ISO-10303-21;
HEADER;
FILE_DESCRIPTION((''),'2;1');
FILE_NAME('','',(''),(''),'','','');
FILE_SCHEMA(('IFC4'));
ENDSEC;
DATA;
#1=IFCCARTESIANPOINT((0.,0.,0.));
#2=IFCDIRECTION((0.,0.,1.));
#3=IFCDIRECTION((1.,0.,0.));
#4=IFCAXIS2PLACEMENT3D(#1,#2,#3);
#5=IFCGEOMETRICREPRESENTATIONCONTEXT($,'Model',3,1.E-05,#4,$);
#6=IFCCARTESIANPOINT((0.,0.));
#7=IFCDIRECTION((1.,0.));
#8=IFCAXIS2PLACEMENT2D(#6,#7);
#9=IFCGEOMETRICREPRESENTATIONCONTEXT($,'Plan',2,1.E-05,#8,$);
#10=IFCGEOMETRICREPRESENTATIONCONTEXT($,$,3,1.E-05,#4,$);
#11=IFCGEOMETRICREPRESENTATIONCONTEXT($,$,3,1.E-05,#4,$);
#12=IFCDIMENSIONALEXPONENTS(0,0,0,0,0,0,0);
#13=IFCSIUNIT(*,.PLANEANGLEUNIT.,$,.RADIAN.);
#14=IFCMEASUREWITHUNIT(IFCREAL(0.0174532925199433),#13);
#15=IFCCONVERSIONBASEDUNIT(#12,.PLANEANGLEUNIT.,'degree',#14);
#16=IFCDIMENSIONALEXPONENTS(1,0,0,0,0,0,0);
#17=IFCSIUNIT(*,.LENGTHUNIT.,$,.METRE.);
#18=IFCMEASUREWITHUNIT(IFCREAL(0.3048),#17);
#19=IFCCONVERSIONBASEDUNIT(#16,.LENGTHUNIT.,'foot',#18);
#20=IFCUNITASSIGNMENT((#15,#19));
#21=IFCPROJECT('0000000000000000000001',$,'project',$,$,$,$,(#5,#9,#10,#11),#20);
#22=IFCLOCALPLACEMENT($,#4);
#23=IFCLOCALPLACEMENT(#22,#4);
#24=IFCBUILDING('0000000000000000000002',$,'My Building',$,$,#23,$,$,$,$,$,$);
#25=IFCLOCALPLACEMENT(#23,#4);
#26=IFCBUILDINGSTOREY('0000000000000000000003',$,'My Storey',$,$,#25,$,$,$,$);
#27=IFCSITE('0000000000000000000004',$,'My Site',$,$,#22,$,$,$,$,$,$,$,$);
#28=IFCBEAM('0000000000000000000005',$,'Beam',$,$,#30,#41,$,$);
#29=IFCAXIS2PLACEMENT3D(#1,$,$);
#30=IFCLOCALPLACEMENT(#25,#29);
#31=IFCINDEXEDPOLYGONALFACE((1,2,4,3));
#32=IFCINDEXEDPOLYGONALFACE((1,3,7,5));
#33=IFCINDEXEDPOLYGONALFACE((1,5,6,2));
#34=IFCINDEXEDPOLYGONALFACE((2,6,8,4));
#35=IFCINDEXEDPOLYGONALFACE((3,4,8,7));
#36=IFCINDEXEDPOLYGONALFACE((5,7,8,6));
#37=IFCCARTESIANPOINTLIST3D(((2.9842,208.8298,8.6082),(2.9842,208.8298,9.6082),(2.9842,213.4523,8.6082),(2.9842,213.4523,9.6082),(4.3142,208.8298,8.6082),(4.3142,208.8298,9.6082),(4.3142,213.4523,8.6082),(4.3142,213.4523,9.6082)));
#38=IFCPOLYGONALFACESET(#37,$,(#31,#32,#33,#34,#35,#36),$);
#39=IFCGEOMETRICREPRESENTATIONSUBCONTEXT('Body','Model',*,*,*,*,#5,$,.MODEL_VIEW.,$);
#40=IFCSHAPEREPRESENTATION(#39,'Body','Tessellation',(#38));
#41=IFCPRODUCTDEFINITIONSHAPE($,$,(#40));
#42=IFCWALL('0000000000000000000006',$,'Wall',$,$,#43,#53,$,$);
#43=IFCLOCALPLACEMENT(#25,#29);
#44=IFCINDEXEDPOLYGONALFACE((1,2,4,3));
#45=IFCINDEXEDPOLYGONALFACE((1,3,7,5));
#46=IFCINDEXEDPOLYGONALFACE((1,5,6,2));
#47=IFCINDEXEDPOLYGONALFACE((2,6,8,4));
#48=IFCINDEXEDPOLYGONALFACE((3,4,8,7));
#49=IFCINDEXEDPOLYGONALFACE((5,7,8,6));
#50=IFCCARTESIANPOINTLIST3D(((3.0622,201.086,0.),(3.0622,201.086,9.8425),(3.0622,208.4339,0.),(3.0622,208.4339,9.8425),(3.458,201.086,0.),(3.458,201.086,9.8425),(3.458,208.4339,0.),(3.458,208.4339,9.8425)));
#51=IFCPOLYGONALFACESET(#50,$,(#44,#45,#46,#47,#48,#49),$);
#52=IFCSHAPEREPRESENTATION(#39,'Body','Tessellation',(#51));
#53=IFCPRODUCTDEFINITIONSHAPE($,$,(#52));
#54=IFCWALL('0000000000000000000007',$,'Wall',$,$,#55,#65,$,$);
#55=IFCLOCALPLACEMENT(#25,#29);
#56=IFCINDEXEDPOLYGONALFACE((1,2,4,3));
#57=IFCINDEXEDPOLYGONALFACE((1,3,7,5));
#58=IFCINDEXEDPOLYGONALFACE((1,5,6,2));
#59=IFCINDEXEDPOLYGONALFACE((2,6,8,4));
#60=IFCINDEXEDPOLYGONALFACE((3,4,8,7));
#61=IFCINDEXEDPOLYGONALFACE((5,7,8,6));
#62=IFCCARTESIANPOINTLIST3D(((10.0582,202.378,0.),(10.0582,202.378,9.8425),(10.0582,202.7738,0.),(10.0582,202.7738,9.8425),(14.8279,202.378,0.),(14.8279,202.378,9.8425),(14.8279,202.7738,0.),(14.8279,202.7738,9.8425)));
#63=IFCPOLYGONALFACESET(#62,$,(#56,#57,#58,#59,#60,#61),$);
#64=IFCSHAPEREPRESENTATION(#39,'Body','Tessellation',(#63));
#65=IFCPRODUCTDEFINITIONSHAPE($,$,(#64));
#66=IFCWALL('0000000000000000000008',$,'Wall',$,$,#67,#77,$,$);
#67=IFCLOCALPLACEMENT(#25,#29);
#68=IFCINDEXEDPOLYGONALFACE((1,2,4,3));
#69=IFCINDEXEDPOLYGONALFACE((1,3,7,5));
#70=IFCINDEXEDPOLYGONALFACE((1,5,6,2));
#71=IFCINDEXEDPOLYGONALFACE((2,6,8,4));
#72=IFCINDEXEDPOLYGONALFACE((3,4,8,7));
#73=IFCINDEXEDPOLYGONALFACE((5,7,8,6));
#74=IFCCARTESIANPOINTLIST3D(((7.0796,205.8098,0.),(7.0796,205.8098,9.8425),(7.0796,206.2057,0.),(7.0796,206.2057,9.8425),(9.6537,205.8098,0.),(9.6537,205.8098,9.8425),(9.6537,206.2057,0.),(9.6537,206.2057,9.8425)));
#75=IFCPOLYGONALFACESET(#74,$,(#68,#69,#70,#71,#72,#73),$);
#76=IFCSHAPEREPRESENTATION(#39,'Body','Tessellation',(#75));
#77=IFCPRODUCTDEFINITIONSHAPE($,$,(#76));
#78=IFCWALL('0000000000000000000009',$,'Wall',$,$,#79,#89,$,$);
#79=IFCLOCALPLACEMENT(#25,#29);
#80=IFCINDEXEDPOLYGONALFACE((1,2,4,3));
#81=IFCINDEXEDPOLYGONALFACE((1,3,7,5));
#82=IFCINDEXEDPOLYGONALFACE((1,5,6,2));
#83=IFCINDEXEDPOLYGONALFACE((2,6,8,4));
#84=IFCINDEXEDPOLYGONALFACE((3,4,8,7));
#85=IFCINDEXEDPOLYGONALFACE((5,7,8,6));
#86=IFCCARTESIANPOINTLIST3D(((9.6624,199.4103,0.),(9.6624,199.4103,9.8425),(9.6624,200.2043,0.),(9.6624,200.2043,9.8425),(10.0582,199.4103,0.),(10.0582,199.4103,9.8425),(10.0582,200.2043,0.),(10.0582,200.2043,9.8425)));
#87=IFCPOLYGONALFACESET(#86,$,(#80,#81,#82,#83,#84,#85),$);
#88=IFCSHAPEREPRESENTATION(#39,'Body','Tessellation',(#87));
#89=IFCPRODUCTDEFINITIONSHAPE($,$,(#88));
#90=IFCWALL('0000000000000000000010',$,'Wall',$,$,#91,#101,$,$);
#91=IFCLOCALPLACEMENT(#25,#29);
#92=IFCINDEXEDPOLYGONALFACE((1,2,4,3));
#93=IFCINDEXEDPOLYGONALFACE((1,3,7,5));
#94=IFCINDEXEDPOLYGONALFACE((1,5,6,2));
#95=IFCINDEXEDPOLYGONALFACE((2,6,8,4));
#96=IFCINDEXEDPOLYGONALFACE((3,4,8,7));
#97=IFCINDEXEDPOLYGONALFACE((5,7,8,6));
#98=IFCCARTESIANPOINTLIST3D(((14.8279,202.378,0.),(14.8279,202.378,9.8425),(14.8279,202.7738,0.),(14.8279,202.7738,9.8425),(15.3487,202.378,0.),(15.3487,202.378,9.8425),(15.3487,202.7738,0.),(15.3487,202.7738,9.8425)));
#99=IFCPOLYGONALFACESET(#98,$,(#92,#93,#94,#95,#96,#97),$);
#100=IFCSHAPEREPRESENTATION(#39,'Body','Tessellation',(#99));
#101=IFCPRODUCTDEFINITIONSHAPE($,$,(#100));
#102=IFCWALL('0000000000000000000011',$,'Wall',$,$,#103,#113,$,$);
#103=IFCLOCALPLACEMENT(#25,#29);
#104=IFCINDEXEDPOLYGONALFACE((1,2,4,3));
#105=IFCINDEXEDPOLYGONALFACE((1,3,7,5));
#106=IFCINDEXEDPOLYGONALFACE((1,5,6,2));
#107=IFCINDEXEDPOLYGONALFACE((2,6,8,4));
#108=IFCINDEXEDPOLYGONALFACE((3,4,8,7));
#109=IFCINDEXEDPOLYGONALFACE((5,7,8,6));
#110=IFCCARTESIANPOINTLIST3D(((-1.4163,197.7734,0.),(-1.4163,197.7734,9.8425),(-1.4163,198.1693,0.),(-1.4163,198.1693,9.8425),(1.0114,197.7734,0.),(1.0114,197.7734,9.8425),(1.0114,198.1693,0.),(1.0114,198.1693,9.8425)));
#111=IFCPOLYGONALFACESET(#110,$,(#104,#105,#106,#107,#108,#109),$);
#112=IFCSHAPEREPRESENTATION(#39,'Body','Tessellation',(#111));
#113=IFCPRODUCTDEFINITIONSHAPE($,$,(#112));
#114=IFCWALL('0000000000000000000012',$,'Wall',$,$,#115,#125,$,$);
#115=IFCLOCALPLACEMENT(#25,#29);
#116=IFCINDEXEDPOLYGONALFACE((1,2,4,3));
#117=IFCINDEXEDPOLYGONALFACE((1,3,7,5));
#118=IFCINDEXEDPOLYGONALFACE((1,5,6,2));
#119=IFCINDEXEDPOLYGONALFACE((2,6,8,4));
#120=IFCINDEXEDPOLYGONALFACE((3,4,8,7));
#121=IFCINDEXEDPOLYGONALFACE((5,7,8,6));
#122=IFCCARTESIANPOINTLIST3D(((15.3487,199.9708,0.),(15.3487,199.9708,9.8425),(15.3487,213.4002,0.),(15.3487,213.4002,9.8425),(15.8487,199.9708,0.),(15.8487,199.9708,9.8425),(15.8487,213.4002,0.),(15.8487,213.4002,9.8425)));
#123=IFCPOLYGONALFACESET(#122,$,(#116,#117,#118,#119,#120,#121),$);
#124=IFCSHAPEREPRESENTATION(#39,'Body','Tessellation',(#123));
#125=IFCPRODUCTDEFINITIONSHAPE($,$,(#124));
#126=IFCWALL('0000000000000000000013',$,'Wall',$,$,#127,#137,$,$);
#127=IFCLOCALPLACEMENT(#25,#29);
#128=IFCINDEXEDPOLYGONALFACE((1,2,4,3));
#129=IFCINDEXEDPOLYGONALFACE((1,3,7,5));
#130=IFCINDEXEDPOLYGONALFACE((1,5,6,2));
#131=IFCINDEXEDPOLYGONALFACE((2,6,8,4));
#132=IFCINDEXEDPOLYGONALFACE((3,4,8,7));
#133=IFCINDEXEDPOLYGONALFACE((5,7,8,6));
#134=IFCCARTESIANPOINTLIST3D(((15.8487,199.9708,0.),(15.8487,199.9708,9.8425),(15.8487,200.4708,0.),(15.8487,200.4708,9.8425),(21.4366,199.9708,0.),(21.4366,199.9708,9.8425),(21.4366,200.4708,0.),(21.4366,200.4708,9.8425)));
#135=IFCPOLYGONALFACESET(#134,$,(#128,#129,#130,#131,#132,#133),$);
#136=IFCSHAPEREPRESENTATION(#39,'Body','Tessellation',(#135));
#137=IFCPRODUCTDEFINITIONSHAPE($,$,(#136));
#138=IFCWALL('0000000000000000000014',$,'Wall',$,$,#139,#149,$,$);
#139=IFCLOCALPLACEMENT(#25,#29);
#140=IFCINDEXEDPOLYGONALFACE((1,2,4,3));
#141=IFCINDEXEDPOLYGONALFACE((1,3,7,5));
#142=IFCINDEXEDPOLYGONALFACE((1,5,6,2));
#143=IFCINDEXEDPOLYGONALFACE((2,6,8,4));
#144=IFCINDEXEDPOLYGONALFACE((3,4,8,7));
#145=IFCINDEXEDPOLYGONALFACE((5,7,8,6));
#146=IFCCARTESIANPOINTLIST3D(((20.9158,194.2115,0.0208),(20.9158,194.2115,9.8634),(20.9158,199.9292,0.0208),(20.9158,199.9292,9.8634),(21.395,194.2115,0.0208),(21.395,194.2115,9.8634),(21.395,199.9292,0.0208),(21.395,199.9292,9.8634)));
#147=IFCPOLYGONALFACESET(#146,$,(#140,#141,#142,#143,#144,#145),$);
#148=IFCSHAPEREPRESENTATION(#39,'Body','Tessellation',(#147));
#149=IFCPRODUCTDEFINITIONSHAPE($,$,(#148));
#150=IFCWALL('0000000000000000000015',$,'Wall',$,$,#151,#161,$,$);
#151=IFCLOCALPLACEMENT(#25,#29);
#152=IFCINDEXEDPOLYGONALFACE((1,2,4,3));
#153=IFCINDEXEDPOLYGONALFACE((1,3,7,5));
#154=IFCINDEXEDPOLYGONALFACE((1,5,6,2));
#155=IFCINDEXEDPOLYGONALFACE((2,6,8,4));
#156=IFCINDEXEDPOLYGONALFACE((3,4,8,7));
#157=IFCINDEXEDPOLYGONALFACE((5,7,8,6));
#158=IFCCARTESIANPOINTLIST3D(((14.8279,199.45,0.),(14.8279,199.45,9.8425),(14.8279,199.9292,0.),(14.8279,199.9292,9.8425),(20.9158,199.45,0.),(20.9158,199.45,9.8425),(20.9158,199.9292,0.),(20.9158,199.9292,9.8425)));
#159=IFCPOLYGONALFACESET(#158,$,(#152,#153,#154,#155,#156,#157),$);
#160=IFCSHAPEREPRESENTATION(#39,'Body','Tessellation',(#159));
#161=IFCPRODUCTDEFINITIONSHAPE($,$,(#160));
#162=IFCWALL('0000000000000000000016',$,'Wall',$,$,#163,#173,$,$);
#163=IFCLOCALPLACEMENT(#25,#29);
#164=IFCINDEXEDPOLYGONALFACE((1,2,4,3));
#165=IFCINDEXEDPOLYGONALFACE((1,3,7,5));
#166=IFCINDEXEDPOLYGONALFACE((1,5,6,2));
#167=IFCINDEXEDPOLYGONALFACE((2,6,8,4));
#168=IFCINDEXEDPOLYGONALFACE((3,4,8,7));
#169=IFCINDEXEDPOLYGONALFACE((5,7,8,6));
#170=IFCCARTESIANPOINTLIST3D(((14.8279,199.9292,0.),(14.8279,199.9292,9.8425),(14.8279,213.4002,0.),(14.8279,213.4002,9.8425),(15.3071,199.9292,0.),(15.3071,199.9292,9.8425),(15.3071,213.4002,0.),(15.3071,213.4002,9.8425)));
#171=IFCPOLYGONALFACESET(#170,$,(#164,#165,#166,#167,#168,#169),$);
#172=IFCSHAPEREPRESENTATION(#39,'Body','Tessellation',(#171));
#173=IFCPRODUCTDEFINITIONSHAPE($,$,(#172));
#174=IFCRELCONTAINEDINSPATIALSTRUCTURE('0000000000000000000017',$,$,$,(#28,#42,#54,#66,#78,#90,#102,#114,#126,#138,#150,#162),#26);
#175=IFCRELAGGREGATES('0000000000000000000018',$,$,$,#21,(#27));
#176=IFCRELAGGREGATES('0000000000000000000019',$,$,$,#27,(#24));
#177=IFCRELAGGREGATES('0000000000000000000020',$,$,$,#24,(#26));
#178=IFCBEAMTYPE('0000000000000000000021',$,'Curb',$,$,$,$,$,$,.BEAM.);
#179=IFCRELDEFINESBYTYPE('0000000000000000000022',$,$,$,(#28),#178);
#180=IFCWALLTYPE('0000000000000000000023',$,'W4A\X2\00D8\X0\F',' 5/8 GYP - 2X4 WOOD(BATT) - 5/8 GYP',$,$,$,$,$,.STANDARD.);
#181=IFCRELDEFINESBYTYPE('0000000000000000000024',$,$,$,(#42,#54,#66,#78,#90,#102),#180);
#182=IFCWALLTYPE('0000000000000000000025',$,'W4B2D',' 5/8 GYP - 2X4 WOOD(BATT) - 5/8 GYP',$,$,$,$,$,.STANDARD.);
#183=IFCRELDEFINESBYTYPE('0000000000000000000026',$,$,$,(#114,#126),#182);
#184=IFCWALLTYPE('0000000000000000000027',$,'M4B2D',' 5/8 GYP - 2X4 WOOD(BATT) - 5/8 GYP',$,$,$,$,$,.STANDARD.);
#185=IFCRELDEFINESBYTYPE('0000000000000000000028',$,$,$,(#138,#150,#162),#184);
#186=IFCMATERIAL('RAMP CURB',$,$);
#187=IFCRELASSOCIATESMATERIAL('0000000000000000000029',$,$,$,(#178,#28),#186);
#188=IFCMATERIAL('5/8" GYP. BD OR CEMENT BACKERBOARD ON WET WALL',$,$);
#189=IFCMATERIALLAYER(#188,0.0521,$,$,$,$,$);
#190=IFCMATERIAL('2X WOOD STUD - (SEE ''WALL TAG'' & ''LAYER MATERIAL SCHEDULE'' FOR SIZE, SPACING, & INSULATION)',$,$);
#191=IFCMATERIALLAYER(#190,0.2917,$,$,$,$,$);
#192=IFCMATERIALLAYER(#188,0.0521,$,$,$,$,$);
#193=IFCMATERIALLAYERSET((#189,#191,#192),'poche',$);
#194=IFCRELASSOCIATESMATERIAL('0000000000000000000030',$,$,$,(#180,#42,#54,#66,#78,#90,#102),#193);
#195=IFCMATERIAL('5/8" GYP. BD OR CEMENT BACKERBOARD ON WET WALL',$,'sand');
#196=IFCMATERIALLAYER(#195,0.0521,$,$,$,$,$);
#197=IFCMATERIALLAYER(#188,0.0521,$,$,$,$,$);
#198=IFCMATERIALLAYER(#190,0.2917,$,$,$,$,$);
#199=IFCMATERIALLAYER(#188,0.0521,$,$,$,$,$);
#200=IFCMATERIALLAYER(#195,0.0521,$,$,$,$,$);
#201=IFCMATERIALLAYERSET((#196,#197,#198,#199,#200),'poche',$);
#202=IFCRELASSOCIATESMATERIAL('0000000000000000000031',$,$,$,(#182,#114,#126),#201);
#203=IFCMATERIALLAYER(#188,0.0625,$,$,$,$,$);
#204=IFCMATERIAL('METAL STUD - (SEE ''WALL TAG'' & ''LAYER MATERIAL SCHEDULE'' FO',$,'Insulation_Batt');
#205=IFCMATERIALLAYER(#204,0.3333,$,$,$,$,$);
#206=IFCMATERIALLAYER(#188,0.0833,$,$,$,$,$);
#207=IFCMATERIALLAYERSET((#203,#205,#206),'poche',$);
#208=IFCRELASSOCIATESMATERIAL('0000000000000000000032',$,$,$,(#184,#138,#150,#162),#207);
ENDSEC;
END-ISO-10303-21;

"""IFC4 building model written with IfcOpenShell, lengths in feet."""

from ifc_helpers import new_model, entity, si_unit, converted_unit, frame, origin_with_axes, origin_2d_with_axis, place, context, subcontext, project, spatial, indexed_curve, rectangle, outline, extrude, material, layer, layer_set, layer_usage, material_profile, profile_set, profile_usage, type_object, element, save


model = new_model("IFC4")

# Units and contexts
model_context = context("Model", 3, precision=1e-05, world=origin_with_axes())
plan_context = context("Plan", 2, precision=1e-05, world=origin_2d_with_axis())
context_of_model_1 = context(None, 3, precision=1e-05, world=origin_with_axes())
context_of_model_2 = context(None, 3, precision=1e-05, world=origin_with_axes())
body_context = subcontext(model_context, "Body", "Model", "MODEL_VIEW")
ifc_project = project(units=[converted_unit("PLANEANGLEUNIT", "degree", entity("IfcReal", 0.0174532925199433), si_unit("PLANEANGLEUNIT", "RADIAN"), dimensions=[0, 0, 0, 0, 0, 0, 0]), converted_unit("LENGTHUNIT", "foot", entity("IfcReal", 0.3048), si_unit("LENGTHUNIT", "METRE"), dimensions=[1, 0, 0, 0, 0, 0, 0])], contexts=[model_context, plan_context, context_of_model_1, context_of_model_2])

# Site, building, storey
site_placement = place(None, origin_with_axes())
site = spatial("IfcSite", under=ifc_project, at=site_placement, Name="My Site")
building_placement = place(site_placement, origin_with_axes())
building = spatial("IfcBuilding", under=site, at=building_placement, Name="My Building")
storey_placement = place(building_placement, origin_with_axes())
storey = spatial("IfcBuildingStorey", under=building, at=storey_placement, Name="My Storey")

# Beam
ifc_material_1 = material(Name="RAMP CURB")
ifc_material_profile = material_profile(ifc_material_1, rectangle(XDim=1.33, YDim=1.0))
ifc_profile_set = profile_set([ifc_material_profile])
ifc_profile_usage = profile_usage(ifc_profile_set, cardinal=5)
beam_type = type_object("IfcBeamType", Name="Curb", PredefinedType="BEAM", material=ifc_profile_set)
beam_placement = place(storey_placement, frame((3.6492, 208.8298, 9.1082), z_axis=(0.0, 1.0, 0.0), x_axis=(-1.0, 0.0, 0.0)))
element("IfcBeam", 1, at=beam_placement, inside=storey, type_object=beam_type, material=ifc_profile_usage, Name="Beam", context=body_context, shape_type="SweptSolid", body=[
    extrude(rectangle(XDim=1.33, YDim=1.0), origin_with_axes(), (0.0, 0.0, 1.0), 4.6225),
])

# Walls
ifc_material_2 = material(Name="5/8\" GYP. BD OR CEMENT BACKERBOARD ON WET WALL")
ifc_layer_1 = layer(ifc_material_2, 0.0521)
ifc_material_3 = material(Name="2X WOOD STUD - (SEE 'WALL TAG' & 'LAYER MATERIAL SCHEDULE' FOR SIZE, SPACING, & INSULATION)")
ifc_layer_2 = layer(ifc_material_3, 0.2917)
ifc_layer_3 = layer(ifc_material_2, 0.0521)
ifc_layer_set_1 = layer_set([ifc_layer_1, ifc_layer_2, ifc_layer_3], Name="poche")
ifc_layer_usage_1 = layer_usage(ifc_layer_set_1, "AXIS2", "POSITIVE", 0.0)
wall_type_1 = type_object("IfcWallType", Name="W4AØF", Description=" 5/8 GYP - 2X4 WOOD(BATT) - 5/8 GYP", PredefinedType="STANDARD", material=ifc_layer_set_1)
wall_1_placement = place(storey_placement, frame((3.458, 201.086, 0.0), z_axis=(0.0, 0.0, 1.0), x_axis=(0.000001, 1.0, 0.0)))
element("IfcWall", 2, at=wall_1_placement, inside=storey, type_object=wall_type_1, material=ifc_layer_usage_1, Name="Wall", context=body_context, shape_type="SweptSolid", body=[
    extrude(outline(indexed_curve([(0.0, 0.0), (0.0, 0.3958), (7.3479, 0.3958), (7.3479, 0.0), (0.0, 0.0)], self_intersect=False)), origin_with_axes(), (0.0, 0.0, 1.0), 9.8425),
])
ifc_layer_usage_2 = layer_usage(ifc_layer_set_1, "AXIS2", "POSITIVE", 0.0)
wall_2_placement = place(storey_placement, frame((10.0582, 202.378, 0.0), z_axis=(0.0, 0.0, 1.0), x_axis=(1.0, 0.0, 0.0)))
element("IfcWall", 3, at=wall_2_placement, inside=storey, type_object=wall_type_1, material=ifc_layer_usage_2, Name="Wall", context=body_context, shape_type="SweptSolid", body=[
    extrude(outline(indexed_curve([(0.0, 0.0), (0.0, 0.3958), (4.7697, 0.3958), (4.7697, 0.0), (0.0, 0.0)], self_intersect=False)), origin_with_axes(), (0.0, 0.0, 1.0), 9.8425),
])
ifc_layer_usage_3 = layer_usage(ifc_layer_set_1, "AXIS2", "POSITIVE", 0.0)
wall_3_placement = place(storey_placement, frame((9.6537, 206.2057, 0.0), z_axis=(0.0, 0.0, 1.0), x_axis=(-1.0, 0.0, 0.0)))
element("IfcWall", 4, at=wall_3_placement, inside=storey, type_object=wall_type_1, material=ifc_layer_usage_3, Name="Wall", context=body_context, shape_type="SweptSolid", body=[
    extrude(outline(indexed_curve([(0.0, 0.0), (0.0, 0.3958), (2.5741, 0.3958), (2.5741, 0.0), (0.0, 0.0)], self_intersect=False)), origin_with_axes(), (0.0, 0.0, 1.0), 9.8425),
])

# Walls
ifc_layer_usage_4 = layer_usage(ifc_layer_set_1, "AXIS2", "POSITIVE", 0.0)
wall_4_placement = place(storey_placement, frame((10.0582, 199.4103, 0.0), z_axis=(0.0, 0.0, 1.0), x_axis=(0.000001, 1.0, 0.0)))
element("IfcWall", 5, at=wall_4_placement, inside=storey, type_object=wall_type_1, material=ifc_layer_usage_4, Name="Wall", context=body_context, shape_type="SweptSolid", body=[
    extrude(outline(indexed_curve([(0.0, 0.0), (0.0, 0.3958), (0.794, 0.3958), (0.794, 0.0), (0.0, 0.0)], self_intersect=False)), origin_with_axes(), (0.0, 0.0, 1.0), 9.8425),
])
ifc_layer_usage_5 = layer_usage(ifc_layer_set_1, "AXIS2", "POSITIVE", 0.0)
wall_5_placement = place(storey_placement, frame((15.3487, 202.7738, 0.0), z_axis=(0.0, 0.0, 1.0), x_axis=(-1.0, 0.0, 0.0)))
element("IfcWall", 6, at=wall_5_placement, inside=storey, type_object=wall_type_1, material=ifc_layer_usage_5, Name="Wall", context=body_context, shape_type="SweptSolid", body=[
    extrude(outline(indexed_curve([(0.0, 0.0), (0.0, 0.3958), (0.5208, 0.3958), (0.5208, 0.0), (0.0, 0.0)], self_intersect=False)), origin_with_axes(), (0.0, 0.0, 1.0), 9.8425),
])
ifc_layer_usage_6 = layer_usage(ifc_layer_set_1, "AXIS2", "POSITIVE", 0.0)
wall_6_placement = place(storey_placement, frame((-1.4163, 197.7734, 0.0), z_axis=(0.0, 0.0, 1.0), x_axis=(1.0, -0.000001, 0.0)))
element("IfcWall", 7, at=wall_6_placement, inside=storey, type_object=wall_type_1, material=ifc_layer_usage_6, Name="Wall", context=body_context, shape_type="SweptSolid", body=[
    extrude(outline(indexed_curve([(0.0, 0.0), (0.0, 0.3958), (2.4277, 0.3958), (2.4277, 0.0), (0.0, 0.0)], self_intersect=False)), origin_with_axes(), (0.0, 0.0, 1.0), 9.8425),
])

# Walls
ifc_material_4 = material(Name="5/8\" GYP. BD OR CEMENT BACKERBOARD ON WET WALL", Category="sand")
ifc_layer_4 = layer(ifc_material_4, 0.0521)
ifc_layer_5 = layer(ifc_material_2, 0.0521)
ifc_layer_6 = layer(ifc_material_3, 0.2917)
ifc_layer_7 = layer(ifc_material_2, 0.0521)
ifc_layer_8 = layer(ifc_material_4, 0.0521)
ifc_layer_set_2 = layer_set([ifc_layer_4, ifc_layer_5, ifc_layer_6, ifc_layer_7, ifc_layer_8], Name="poche")
ifc_layer_usage_7 = layer_usage(ifc_layer_set_2, "AXIS2", "POSITIVE", 0.0)
wall_type_2 = type_object("IfcWallType", Name="W4B2D", Description=" 5/8 GYP - 2X4 WOOD(BATT) - 5/8 GYP", PredefinedType="STANDARD", material=ifc_layer_set_2)
wall_7_placement = place(storey_placement, frame((15.8487, 199.9708, 0.0), z_axis=(0.0, 0.0, 1.0), x_axis=(0.000001, 1.0, 0.0)))
element("IfcWall", 8, at=wall_7_placement, inside=storey, type_object=wall_type_2, material=ifc_layer_usage_7, Name="Wall", context=body_context, shape_type="SweptSolid", body=[
    extrude(outline(indexed_curve([(0.0, 0.0), (0.0, 0.5), (13.4294, 0.5), (13.4294, 0.0), (0.0, 0.0)], self_intersect=False)), origin_with_axes(), (0.0, 0.0, 1.0), 9.8425),
])
ifc_layer_usage_8 = layer_usage(ifc_layer_set_2, "AXIS2", "POSITIVE", 0.0)
wall_8_placement = place(storey_placement, frame((15.8487, 199.9708, 0.0), z_axis=(0.0, 0.0, 1.0), x_axis=(1.0, 0.0, 0.0)))
element("IfcWall", 9, at=wall_8_placement, inside=storey, type_object=wall_type_2, material=ifc_layer_usage_8, Name="Wall", context=body_context, shape_type="SweptSolid", body=[
    extrude(outline(indexed_curve([(0.0, 0.0), (0.0, 0.5), (5.5879, 0.5), (5.5879, 0.0), (0.0, 0.0)], self_intersect=False)), origin_with_axes(), (0.0, 0.0, 1.0), 9.8425),
])
ifc_layer_9 = layer(ifc_material_2, 0.0625)
ifc_material_5 = material(Name="METAL STUD - (SEE 'WALL TAG' & 'LAYER MATERIAL SCHEDULE' FO", Category="Insulation_Batt")
ifc_layer_10 = layer(ifc_material_5, 0.3333)
ifc_layer_11 = layer(ifc_material_2, 0.0833)
ifc_layer_set_3 = layer_set([ifc_layer_9, ifc_layer_10, ifc_layer_11], Name="poche")
ifc_layer_usage_9 = layer_usage(ifc_layer_set_3, "AXIS2", "POSITIVE", 0.0)
wall_type_3 = type_object("IfcWallType", Name="M4B2D", Description=" 5/8 GYP - 2X4 WOOD(BATT) - 5/8 GYP", PredefinedType="STANDARD", material=ifc_layer_set_3)
wall_9_placement = place(storey_placement, frame((20.9158, 199.9292, 0.0208), z_axis=(0.0, 0.0, 1.0), x_axis=(0.0, -1.0, 0.0)))
element("IfcWall", 10, at=wall_9_placement, inside=storey, type_object=wall_type_3, material=ifc_layer_usage_9, Name="Wall", context=body_context, shape_type="SweptSolid", body=[
    extrude(outline(indexed_curve([(0.0, 0.0), (0.0, 0.4792), (5.7176, 0.4792), (5.7176, 0.0), (0.0, 0.0)], self_intersect=False)), origin_with_axes(), (0.0, 0.0, 1.0), 9.8425),
])
ifc_layer_usage_10 = layer_usage(ifc_layer_set_3, "AXIS2", "POSITIVE", 0.0)
wall_10_placement = place(storey_placement, frame((14.8279, 199.45, 0.0), z_axis=(0.0, 0.0, 1.0), x_axis=(1.0, 0.0, 0.0)))
element("IfcWall", 11, at=wall_10_placement, inside=storey, type_object=wall_type_3, material=ifc_layer_usage_10, Name="Wall", context=body_context, shape_type="SweptSolid", body=[
    extrude(outline(indexed_curve([(0.0, 0.0), (0.0, 0.4792), (6.0879, 0.4792), (6.0879, 0.0), (0.0, 0.0)], self_intersect=False)), origin_with_axes(), (0.0, 0.0, 1.0), 9.8425),
])
ifc_layer_usage_11 = layer_usage(ifc_layer_set_3, "AXIS2", "POSITIVE", 0.0)
wall_11_placement = place(storey_placement, frame((15.3071, 199.9292, 0.0), z_axis=(0.0, 0.0, 1.0), x_axis=(0.000001, 1.0, 0.0)))
element("IfcWall", 12, at=wall_11_placement, inside=storey, type_object=wall_type_3, material=ifc_layer_usage_11, Name="Wall", context=body_context, shape_type="SweptSolid", body=[
    extrude(outline(indexed_curve([(0.0, 0.0), (0.0, 0.4792), (13.4711, 0.4792), (13.4711, 0.0), (0.0, 0.0)], self_intersect=False)), origin_with_axes(), (0.0, 0.0, 1.0), 9.8425),
])

save(model, "model.ifc")
